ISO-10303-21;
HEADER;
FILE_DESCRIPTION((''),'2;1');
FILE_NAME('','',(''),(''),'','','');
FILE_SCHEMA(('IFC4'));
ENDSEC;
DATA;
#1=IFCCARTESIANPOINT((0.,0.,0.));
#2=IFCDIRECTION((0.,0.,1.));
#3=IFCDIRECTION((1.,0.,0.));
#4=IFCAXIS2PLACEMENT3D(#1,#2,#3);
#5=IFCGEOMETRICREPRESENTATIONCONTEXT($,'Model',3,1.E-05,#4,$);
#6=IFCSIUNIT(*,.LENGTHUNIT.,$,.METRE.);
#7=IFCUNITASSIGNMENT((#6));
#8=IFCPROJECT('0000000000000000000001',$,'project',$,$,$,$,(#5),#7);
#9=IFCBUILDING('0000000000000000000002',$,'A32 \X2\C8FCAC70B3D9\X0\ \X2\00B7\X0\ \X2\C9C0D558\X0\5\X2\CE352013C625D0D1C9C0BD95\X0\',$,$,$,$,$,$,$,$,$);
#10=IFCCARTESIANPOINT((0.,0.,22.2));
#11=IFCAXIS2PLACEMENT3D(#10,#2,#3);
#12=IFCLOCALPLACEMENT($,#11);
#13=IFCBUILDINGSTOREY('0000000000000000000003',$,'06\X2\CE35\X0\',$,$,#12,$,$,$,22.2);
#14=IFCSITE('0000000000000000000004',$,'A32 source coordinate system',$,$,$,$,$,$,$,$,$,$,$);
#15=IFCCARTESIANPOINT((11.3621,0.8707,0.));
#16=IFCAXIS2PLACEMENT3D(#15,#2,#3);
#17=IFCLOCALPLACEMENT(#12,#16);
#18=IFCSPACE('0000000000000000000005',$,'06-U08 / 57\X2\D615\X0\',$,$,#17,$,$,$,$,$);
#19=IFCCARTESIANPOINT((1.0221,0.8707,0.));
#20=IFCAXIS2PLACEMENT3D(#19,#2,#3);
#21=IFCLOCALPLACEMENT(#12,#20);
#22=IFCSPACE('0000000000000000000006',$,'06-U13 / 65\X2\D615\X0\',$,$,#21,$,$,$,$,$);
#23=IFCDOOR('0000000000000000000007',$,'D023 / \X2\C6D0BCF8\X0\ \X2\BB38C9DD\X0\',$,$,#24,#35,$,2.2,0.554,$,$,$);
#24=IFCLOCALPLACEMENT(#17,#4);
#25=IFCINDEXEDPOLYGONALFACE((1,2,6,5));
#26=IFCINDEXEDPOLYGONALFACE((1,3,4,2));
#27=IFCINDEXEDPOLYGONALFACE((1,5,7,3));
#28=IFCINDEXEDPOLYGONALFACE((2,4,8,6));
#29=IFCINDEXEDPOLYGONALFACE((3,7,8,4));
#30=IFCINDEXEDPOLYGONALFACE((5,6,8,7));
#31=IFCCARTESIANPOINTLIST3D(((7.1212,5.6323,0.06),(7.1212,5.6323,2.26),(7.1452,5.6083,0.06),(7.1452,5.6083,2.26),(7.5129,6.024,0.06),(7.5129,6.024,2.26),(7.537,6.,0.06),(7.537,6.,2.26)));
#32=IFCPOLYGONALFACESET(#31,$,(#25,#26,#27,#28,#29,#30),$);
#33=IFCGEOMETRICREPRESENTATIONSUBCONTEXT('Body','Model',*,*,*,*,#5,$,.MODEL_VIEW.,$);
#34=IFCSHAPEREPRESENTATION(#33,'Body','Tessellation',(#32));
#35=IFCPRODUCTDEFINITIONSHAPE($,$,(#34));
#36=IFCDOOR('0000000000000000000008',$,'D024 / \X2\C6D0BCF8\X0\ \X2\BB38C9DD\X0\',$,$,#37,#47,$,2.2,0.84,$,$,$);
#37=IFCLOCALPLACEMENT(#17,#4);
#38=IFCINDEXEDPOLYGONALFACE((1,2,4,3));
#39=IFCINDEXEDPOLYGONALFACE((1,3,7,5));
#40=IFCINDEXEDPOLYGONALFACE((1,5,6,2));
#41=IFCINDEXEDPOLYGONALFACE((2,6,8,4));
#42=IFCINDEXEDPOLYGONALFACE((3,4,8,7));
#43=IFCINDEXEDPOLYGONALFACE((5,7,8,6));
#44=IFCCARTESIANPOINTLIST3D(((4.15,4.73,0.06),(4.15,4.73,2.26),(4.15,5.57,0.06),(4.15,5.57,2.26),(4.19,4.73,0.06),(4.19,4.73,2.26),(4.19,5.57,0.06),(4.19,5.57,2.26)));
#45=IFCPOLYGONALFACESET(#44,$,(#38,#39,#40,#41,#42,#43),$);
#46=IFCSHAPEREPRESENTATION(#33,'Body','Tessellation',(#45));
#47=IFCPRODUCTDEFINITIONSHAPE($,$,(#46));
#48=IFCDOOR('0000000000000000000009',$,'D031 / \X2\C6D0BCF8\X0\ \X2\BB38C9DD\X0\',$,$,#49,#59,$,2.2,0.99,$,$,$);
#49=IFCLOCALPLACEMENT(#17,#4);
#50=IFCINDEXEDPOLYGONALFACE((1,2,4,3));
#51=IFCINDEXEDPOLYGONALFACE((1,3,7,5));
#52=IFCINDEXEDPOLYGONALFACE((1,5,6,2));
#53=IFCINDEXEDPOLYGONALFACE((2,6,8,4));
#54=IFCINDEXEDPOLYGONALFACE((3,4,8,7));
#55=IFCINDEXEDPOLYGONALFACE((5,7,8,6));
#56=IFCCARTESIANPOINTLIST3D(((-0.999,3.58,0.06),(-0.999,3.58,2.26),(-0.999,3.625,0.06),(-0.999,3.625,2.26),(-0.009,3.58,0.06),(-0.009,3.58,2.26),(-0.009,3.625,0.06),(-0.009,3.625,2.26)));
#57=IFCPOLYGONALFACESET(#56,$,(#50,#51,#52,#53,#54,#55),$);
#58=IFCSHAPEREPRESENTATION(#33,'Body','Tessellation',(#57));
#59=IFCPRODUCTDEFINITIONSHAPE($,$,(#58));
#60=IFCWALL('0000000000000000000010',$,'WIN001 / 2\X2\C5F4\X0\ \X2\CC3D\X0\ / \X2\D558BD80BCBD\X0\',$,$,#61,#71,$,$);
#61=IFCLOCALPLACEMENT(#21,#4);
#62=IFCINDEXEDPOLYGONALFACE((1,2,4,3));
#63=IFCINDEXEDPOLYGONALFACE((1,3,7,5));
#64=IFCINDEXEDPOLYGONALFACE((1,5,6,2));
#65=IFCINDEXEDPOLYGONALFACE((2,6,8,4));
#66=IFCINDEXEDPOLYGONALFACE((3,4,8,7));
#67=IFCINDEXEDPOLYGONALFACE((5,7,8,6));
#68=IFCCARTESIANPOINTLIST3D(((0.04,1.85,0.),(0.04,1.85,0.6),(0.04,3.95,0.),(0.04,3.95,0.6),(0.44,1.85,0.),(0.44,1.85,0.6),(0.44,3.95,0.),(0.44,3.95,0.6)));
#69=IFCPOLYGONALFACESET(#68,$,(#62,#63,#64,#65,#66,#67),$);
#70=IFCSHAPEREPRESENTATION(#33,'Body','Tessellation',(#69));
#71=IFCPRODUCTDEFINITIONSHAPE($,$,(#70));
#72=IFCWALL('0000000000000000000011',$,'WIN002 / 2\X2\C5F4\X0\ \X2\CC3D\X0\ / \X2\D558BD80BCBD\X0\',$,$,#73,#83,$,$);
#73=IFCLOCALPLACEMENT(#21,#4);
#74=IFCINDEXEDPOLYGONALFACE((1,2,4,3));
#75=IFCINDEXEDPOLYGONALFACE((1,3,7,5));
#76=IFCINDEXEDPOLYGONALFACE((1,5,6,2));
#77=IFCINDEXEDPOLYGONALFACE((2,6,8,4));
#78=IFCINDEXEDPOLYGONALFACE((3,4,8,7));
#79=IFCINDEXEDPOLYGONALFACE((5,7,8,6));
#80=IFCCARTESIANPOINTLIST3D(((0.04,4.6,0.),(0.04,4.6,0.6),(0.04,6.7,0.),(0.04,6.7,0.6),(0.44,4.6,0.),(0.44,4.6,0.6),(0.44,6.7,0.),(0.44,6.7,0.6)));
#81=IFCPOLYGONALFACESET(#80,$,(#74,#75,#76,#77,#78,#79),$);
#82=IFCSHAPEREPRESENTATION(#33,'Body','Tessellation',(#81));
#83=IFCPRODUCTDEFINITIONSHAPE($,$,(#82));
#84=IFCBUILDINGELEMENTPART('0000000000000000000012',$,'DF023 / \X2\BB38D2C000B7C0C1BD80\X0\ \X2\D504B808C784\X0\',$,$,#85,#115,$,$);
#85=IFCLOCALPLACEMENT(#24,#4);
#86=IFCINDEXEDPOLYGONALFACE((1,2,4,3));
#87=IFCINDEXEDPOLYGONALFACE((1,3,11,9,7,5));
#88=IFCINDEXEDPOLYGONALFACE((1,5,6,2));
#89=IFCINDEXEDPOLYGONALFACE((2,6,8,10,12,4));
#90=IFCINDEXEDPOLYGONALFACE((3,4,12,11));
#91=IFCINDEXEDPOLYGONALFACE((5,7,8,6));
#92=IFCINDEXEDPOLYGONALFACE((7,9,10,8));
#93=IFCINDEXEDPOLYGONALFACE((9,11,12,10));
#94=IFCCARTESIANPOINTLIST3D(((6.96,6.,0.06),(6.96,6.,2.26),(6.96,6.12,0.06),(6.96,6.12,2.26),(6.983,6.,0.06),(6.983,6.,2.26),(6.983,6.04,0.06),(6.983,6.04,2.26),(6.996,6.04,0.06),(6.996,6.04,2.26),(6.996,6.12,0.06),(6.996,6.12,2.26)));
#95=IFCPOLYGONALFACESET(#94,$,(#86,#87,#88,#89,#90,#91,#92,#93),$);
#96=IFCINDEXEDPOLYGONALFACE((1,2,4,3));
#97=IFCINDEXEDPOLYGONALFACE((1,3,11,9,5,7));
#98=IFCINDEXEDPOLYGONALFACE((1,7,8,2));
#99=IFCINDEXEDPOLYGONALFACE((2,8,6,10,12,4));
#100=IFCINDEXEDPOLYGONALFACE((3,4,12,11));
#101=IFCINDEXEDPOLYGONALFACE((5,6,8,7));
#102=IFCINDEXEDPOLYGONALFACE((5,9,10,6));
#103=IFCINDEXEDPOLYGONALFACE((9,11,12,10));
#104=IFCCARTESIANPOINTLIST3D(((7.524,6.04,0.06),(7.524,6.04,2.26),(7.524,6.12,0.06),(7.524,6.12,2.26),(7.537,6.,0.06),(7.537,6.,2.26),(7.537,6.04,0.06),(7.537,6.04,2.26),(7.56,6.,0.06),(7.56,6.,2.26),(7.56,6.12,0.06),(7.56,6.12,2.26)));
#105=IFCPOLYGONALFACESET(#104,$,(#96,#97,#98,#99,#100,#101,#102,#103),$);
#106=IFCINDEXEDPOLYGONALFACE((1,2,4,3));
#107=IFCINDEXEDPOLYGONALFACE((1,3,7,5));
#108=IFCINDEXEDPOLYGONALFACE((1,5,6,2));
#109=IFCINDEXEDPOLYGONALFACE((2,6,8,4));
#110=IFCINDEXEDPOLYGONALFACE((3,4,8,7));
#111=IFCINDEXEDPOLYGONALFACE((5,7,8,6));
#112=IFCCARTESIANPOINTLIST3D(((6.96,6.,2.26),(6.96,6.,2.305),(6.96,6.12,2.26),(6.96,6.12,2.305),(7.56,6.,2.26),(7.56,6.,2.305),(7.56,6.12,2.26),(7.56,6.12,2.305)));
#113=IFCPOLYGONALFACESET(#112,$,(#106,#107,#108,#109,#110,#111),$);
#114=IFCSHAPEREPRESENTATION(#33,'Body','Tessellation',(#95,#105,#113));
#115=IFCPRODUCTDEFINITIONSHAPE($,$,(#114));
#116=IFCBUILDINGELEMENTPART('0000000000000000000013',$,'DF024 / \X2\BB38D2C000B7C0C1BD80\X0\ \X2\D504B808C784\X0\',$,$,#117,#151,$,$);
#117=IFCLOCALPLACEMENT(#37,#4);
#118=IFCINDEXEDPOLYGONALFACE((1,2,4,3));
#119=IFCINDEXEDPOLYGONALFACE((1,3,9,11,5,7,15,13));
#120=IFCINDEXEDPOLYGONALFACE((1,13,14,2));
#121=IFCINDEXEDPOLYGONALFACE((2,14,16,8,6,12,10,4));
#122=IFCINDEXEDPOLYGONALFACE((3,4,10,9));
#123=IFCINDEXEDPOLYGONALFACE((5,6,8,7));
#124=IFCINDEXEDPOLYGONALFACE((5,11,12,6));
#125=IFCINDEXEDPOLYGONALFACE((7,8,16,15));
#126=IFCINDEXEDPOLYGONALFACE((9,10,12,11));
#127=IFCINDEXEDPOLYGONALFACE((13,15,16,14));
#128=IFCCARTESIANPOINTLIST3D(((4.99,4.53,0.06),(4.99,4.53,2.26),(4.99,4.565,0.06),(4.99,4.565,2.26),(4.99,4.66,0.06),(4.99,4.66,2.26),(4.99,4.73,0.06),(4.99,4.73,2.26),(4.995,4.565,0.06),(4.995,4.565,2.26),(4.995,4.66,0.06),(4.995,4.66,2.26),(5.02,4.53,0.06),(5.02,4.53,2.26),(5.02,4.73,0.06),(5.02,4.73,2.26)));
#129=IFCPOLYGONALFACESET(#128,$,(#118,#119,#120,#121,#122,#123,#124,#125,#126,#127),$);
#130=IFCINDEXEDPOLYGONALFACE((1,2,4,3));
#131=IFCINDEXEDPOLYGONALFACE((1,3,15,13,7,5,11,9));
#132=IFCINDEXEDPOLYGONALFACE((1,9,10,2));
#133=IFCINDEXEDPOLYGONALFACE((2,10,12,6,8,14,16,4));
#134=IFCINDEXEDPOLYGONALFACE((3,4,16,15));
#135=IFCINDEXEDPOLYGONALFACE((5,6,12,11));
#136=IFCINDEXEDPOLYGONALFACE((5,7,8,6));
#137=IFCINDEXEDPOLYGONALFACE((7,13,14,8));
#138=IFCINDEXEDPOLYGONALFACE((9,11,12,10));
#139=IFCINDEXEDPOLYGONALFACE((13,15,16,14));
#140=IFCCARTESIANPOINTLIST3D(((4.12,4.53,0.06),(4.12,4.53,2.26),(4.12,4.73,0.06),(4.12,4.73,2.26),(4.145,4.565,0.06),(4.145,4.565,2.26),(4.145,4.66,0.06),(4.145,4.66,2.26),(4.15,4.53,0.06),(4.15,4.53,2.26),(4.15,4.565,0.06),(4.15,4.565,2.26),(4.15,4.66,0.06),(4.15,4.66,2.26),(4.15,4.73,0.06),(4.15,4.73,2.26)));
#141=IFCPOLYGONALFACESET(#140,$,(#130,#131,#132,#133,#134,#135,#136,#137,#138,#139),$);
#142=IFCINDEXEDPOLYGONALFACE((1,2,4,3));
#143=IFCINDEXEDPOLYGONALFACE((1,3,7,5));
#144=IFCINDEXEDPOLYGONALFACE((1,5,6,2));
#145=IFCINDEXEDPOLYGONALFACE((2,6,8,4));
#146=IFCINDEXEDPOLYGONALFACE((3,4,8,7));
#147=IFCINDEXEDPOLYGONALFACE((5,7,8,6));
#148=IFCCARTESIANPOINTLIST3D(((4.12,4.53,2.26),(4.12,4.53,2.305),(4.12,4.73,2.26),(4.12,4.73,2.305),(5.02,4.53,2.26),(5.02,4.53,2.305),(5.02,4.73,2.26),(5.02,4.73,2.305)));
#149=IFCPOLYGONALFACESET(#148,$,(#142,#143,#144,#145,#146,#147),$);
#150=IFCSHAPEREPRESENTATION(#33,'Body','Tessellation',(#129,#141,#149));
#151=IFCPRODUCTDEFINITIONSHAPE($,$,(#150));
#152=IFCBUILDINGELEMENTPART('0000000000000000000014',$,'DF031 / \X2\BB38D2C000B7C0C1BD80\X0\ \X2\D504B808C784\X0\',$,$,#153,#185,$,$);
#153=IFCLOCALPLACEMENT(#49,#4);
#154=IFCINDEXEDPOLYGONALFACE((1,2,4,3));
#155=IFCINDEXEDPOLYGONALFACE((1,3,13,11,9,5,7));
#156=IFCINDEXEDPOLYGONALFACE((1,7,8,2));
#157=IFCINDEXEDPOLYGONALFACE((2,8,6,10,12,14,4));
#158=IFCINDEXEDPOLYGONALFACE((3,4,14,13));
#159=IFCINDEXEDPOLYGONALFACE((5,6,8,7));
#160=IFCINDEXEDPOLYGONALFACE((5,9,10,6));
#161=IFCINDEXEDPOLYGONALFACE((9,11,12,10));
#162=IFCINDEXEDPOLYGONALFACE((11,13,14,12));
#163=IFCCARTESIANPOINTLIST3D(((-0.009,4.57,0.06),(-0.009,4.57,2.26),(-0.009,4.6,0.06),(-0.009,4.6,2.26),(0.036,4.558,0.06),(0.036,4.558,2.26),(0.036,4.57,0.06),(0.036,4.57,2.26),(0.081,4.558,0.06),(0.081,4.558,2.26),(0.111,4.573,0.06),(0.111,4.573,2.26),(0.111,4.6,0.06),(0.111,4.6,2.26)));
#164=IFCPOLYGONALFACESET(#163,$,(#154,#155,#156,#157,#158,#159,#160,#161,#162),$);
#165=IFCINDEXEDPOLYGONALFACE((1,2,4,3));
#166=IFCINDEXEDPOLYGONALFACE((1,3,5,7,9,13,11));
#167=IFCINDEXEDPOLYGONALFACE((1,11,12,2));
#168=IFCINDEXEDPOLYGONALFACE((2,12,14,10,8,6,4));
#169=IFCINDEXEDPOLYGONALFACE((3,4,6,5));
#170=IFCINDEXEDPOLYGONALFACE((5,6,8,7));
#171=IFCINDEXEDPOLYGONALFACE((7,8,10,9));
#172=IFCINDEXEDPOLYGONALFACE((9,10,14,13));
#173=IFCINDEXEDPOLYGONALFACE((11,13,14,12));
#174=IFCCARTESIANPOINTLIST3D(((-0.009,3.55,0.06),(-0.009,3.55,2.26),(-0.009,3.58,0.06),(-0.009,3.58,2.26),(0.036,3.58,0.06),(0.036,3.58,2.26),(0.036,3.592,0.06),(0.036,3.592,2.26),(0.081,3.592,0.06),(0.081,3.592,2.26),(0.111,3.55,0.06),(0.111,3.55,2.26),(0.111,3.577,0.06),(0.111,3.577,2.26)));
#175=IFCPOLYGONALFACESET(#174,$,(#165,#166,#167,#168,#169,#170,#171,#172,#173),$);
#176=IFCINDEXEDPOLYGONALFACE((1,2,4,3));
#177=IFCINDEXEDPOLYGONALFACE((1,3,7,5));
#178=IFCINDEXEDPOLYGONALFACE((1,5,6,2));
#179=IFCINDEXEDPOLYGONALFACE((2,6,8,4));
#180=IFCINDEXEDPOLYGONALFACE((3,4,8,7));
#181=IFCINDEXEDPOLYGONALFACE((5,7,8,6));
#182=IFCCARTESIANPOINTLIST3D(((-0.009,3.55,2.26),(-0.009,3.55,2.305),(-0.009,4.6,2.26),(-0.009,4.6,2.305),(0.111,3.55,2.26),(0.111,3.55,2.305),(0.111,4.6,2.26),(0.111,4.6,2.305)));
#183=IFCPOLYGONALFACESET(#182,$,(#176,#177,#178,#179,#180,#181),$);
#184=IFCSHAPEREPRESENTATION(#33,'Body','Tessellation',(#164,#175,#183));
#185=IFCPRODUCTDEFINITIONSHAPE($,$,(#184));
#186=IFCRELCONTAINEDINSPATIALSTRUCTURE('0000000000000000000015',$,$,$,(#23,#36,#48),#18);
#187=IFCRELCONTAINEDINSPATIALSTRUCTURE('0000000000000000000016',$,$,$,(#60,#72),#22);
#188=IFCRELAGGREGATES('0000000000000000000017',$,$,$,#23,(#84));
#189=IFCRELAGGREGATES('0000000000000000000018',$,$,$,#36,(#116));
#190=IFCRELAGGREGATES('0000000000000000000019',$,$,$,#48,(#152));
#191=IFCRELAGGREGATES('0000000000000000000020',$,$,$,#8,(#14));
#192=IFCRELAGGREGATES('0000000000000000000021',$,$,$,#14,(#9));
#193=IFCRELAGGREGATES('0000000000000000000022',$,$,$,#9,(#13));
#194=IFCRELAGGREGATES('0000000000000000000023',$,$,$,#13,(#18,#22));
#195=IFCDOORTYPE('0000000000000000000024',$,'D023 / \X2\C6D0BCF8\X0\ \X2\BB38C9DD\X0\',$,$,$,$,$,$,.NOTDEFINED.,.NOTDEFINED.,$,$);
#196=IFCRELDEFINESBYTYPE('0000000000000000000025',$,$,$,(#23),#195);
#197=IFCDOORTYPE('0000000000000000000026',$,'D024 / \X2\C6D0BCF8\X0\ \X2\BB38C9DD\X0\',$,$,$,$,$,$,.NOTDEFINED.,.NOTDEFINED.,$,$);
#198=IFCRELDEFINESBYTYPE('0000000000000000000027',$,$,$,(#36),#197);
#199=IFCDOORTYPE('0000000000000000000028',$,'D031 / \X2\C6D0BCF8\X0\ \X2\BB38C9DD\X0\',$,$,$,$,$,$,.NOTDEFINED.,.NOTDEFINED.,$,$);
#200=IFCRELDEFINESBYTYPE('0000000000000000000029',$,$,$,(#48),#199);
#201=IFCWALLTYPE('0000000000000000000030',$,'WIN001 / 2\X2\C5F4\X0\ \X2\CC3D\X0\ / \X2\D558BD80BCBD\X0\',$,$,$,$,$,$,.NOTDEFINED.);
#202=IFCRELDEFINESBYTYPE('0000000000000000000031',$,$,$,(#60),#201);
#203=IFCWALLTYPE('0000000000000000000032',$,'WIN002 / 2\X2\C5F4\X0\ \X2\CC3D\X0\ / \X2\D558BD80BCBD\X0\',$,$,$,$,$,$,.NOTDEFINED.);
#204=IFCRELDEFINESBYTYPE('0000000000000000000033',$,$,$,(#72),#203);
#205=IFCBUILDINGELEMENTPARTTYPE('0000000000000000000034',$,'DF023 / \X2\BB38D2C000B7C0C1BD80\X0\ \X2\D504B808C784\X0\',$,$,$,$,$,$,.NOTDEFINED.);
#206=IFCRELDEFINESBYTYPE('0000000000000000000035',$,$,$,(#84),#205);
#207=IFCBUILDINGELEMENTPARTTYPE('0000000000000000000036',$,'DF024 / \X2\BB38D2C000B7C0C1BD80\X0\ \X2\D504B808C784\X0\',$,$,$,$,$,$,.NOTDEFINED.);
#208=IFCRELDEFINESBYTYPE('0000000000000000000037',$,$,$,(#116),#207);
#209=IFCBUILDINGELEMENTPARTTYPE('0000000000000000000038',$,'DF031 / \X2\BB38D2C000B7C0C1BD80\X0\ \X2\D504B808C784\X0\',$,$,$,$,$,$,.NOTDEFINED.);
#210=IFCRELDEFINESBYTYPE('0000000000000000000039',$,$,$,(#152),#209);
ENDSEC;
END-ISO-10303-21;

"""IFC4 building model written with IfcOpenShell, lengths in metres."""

from ifc_helpers import new_model, si_unit, frame, origin, origin_with_axes, place, context, subcontext, project, spatial, polyline, outline, extrude, source, transform, mapped, type_object, type_shapes, element, aggregate, save


model = new_model("IFC4")

# Units and contexts
model_context = context("Model", 3, precision=1e-05, world=origin_with_axes())
body_context = subcontext(model_context, "Body", "Model", "MODEL_VIEW")
ifc_project = project(units=[si_unit("LENGTHUNIT", "METRE")], contexts=[model_context])

# Site, building, storey, space
site = spatial("IfcSite", under=ifc_project, Name="A32 source coordinate system")
building = spatial("IfcBuilding", under=site, Name="A32 주거동 · 지하5층–옥탑지붕")
storey_placement = place(None, frame((0.0, 0.0, 22.2), z_axis=(0.0, 0.0, 1.0), x_axis=(1.0, 0.0, 0.0)))
storey = spatial("IfcBuildingStorey", under=building, at=storey_placement, Name="06층", Elevation=22.2)
space_1_placement = place(storey_placement, frame((11.3621, 0.8707, 0.0), z_axis=(0.0, 0.0, 1.0), x_axis=(1.0, 0.0, 0.0)))
space_1 = spatial("IfcSpace", under=storey, at=space_1_placement, Name="06-U08 / 57형")

# Doors
door_type_1 = type_object("IfcDoorType", Name="D023 / 원본 문짝", OperationType="NOTDEFINED", PredefinedType="NOTDEFINED")
shared_shape_1 = source(origin(), body_context, "Body", "SweptSolid", [
    extrude(outline(polyline([(7.537, 6.0), (7.1452, 5.6083), (7.1212, 5.6323), (7.5129, 6.024), (7.537, 6.0)])), frame((0.0, 0.0, 0.06)), (0.0, 0.0, 1.0), 2.2),
])
type_shapes(door_type_1, [shared_shape_1])
door_1_placement = place(space_1_placement, origin_with_axes())
door_1 = element("IfcDoor", 1, at=door_1_placement, inside=space_1, type_object=door_type_1, Name="D023 / 원본 문짝", OverallHeight=2.2, OverallWidth=0.554, context=body_context, shape_type="MappedRepresentation", body=[
    mapped(shared_shape_1, transform((0.0, 0.0, 0.0), scale=1.0)),
])
door_type_2 = type_object("IfcDoorType", Name="D024 / 원본 문짝", OperationType="NOTDEFINED", PredefinedType="NOTDEFINED")
shared_shape_2 = source(origin(), body_context, "Body", "SweptSolid", [
    extrude(outline(polyline([(4.15, 4.73), (4.15, 5.57), (4.19, 5.57), (4.19, 4.73), (4.15, 4.73)])), frame((0.0, 0.0, 0.06)), (0.0, 0.0, 1.0), 2.2),
])
type_shapes(door_type_2, [shared_shape_2])
door_2_placement = place(space_1_placement, origin_with_axes())
door_2 = element("IfcDoor", 2, at=door_2_placement, inside=space_1, type_object=door_type_2, Name="D024 / 원본 문짝", OverallHeight=2.2, OverallWidth=0.84, context=body_context, shape_type="MappedRepresentation", body=[
    mapped(shared_shape_2, transform((0.0, 0.0, 0.0), scale=1.0)),
])
door_type_3 = type_object("IfcDoorType", Name="D031 / 원본 문짝", OperationType="NOTDEFINED", PredefinedType="NOTDEFINED")
shared_shape_3 = source(origin(), body_context, "Body", "SweptSolid", [
    extrude(outline(polyline([(-0.009, 3.58), (-0.999, 3.58), (-0.999, 3.625), (-0.009, 3.625), (-0.009, 3.58)])), frame((0.0, 0.0, 0.06)), (0.0, 0.0, 1.0), 2.2),
])
type_shapes(door_type_3, [shared_shape_3])
door_3_placement = place(space_1_placement, origin_with_axes())
door_3 = element("IfcDoor", 3, at=door_3_placement, inside=space_1, type_object=door_type_3, Name="D031 / 원본 문짝", OverallHeight=2.2, OverallWidth=0.99, context=body_context, shape_type="MappedRepresentation", body=[
    mapped(shared_shape_3, transform((0.0, 0.0, 0.0), scale=1.0)),
])

# Shared definitions
space_2_placement = place(storey_placement, frame((1.0221, 0.8707, 0.0), z_axis=(0.0, 0.0, 1.0), x_axis=(1.0, 0.0, 0.0)))
space_2 = spatial("IfcSpace", under=storey, at=space_2_placement, Name="06-U13 / 65형")

# Walls
wall_type_1 = type_object("IfcWallType", Name="WIN001 / 2열 창 / 하부벽", PredefinedType="NOTDEFINED")
shared_shape_4 = source(origin(), body_context, "Body", "SweptSolid", [
    extrude(outline(polyline([(0.04, 3.95), (0.44, 3.95), (0.44, 1.85), (0.04, 1.85), (0.04, 3.95)])), origin(), (0.0, 0.0, 1.0), 0.6),
])
type_shapes(wall_type_1, [shared_shape_4])
wall_1_placement = place(space_2_placement, origin_with_axes())
element("IfcWall", 4, at=wall_1_placement, inside=space_2, type_object=wall_type_1, Name="WIN001 / 2열 창 / 하부벽", context=body_context, shape_type="MappedRepresentation", body=[
    mapped(shared_shape_4, transform((0.0, 0.0, 0.0), scale=1.0)),
])
wall_type_2 = type_object("IfcWallType", Name="WIN002 / 2열 창 / 하부벽", PredefinedType="NOTDEFINED")
shared_shape_5 = source(origin(), body_context, "Body", "SweptSolid", [
    extrude(outline(polyline([(0.04, 6.7), (0.44, 6.7), (0.44, 4.6), (0.04, 4.6), (0.04, 6.7)])), origin(), (0.0, 0.0, 1.0), 0.6),
])
type_shapes(wall_type_2, [shared_shape_5])
wall_2_placement = place(space_2_placement, origin_with_axes())
element("IfcWall", 5, at=wall_2_placement, inside=space_2, type_object=wall_type_2, Name="WIN002 / 2열 창 / 하부벽", context=body_context, shape_type="MappedRepresentation", body=[
    mapped(shared_shape_5, transform((0.0, 0.0, 0.0), scale=1.0)),
])

# Building element parts
building_element_part_type_1 = type_object("IfcBuildingElementPartType", Name="DF023 / 문틀·상부 프레임", PredefinedType="NOTDEFINED")
shared_shape_6 = source(origin(), body_context, "Body", "SweptSolid", [
    extrude(outline(polyline([(6.996, 6.12), (6.996, 6.04), (6.983, 6.04), (6.983, 6.0), (6.96, 6.0), (6.96, 6.12), (6.996, 6.12)])), frame((0.0, 0.0, 0.06)), (0.0, 0.0, 1.0), 2.2),
    extrude(outline(polyline([(7.56, 6.0), (7.537, 6.0), (7.537, 6.04), (7.524, 6.04), (7.524, 6.12), (7.56, 6.12), (7.56, 6.0)])), frame((0.0, 0.0, 0.06)), (0.0, 0.0, 1.0), 2.2),
    extrude(outline(polyline([(6.96, 6.0), (6.96, 6.12), (7.56, 6.12), (7.56, 6.0), (6.96, 6.0)])), frame((0.0, 0.0, 2.26)), (0.0, 0.0, 1.0), 0.045),
])
type_shapes(building_element_part_type_1, [shared_shape_6])
building_element_part_1_placement = place(door_1_placement, origin_with_axes())
building_element_part_1 = element("IfcBuildingElementPart", 6, at=building_element_part_1_placement, type_object=building_element_part_type_1, Name="DF023 / 문틀·상부 프레임", context=body_context, shape_type="MappedRepresentation", body=[
    mapped(shared_shape_6, transform((0.0, 0.0, 0.0), scale=1.0)),
])
aggregate(door_1, [building_element_part_1])
building_element_part_type_2 = type_object("IfcBuildingElementPartType", Name="DF024 / 문틀·상부 프레임", PredefinedType="NOTDEFINED")
shared_shape_7 = source(origin(), body_context, "Body", "SweptSolid", [
    extrude(outline(polyline([(5.02, 4.53), (4.99, 4.53), (4.99, 4.565), (4.995, 4.565), (4.995, 4.66), (4.99, 4.66), (4.99, 4.73), (5.02, 4.73), (5.02, 4.53)])), frame((0.0, 0.0, 0.06)), (0.0, 0.0, 1.0), 2.2),
    extrude(outline(polyline([(4.15, 4.73), (4.15, 4.66), (4.145, 4.66), (4.145, 4.565), (4.15, 4.565), (4.15, 4.53), (4.12, 4.53), (4.12, 4.73), (4.15, 4.73)])), frame((0.0, 0.0, 0.06)), (0.0, 0.0, 1.0), 2.2),
    extrude(outline(polyline([(4.12, 4.53), (4.12, 4.73), (5.02, 4.73), (5.02, 4.53), (4.12, 4.53)])), frame((0.0, 0.0, 2.26)), (0.0, 0.0, 1.0), 0.045),
])
type_shapes(building_element_part_type_2, [shared_shape_7])
building_element_part_2_placement = place(door_2_placement, origin_with_axes())
building_element_part_2 = element("IfcBuildingElementPart", 7, at=building_element_part_2_placement, type_object=building_element_part_type_2, Name="DF024 / 문틀·상부 프레임", context=body_context, shape_type="MappedRepresentation", body=[
    mapped(shared_shape_7, transform((0.0, 0.0, 0.0), scale=1.0)),
])
aggregate(door_2, [building_element_part_2])
building_element_part_type_3 = type_object("IfcBuildingElementPartType", Name="DF031 / 문틀·상부 프레임", PredefinedType="NOTDEFINED")
shared_shape_8 = source(origin(), body_context, "Body", "SweptSolid", [
    extrude(outline(polyline([(0.111, 4.6), (0.111, 4.573), (0.081, 4.558), (0.036, 4.558), (0.036, 4.57), (-0.009, 4.57), (-0.009, 4.6), (0.111, 4.6)])), frame((0.0, 0.0, 0.06)), (0.0, 0.0, 1.0), 2.2),
    extrude(outline(polyline([(-0.009, 3.58), (0.036, 3.58), (0.036, 3.592), (0.081, 3.592), (0.111, 3.577), (0.111, 3.55), (-0.009, 3.55), (-0.009, 3.58)])), frame((0.0, 0.0, 0.06)), (0.0, 0.0, 1.0), 2.2),
    extrude(outline(polyline([(-0.009, 3.55), (-0.009, 4.6), (0.111, 4.6), (0.111, 3.55), (-0.009, 3.55)])), frame((0.0, 0.0, 2.26)), (0.0, 0.0, 1.0), 0.045),
])
type_shapes(building_element_part_type_3, [shared_shape_8])
building_element_part_3_placement = place(door_3_placement, origin_with_axes())
building_element_part_3 = element("IfcBuildingElementPart", 8, at=building_element_part_3_placement, type_object=building_element_part_type_3, Name="DF031 / 문틀·상부 프레임", context=body_context, shape_type="MappedRepresentation", body=[
    mapped(shared_shape_8, transform((0.0, 0.0, 0.0), scale=1.0)),
])
aggregate(door_3, [building_element_part_3])

save(model, "model.ifc")
